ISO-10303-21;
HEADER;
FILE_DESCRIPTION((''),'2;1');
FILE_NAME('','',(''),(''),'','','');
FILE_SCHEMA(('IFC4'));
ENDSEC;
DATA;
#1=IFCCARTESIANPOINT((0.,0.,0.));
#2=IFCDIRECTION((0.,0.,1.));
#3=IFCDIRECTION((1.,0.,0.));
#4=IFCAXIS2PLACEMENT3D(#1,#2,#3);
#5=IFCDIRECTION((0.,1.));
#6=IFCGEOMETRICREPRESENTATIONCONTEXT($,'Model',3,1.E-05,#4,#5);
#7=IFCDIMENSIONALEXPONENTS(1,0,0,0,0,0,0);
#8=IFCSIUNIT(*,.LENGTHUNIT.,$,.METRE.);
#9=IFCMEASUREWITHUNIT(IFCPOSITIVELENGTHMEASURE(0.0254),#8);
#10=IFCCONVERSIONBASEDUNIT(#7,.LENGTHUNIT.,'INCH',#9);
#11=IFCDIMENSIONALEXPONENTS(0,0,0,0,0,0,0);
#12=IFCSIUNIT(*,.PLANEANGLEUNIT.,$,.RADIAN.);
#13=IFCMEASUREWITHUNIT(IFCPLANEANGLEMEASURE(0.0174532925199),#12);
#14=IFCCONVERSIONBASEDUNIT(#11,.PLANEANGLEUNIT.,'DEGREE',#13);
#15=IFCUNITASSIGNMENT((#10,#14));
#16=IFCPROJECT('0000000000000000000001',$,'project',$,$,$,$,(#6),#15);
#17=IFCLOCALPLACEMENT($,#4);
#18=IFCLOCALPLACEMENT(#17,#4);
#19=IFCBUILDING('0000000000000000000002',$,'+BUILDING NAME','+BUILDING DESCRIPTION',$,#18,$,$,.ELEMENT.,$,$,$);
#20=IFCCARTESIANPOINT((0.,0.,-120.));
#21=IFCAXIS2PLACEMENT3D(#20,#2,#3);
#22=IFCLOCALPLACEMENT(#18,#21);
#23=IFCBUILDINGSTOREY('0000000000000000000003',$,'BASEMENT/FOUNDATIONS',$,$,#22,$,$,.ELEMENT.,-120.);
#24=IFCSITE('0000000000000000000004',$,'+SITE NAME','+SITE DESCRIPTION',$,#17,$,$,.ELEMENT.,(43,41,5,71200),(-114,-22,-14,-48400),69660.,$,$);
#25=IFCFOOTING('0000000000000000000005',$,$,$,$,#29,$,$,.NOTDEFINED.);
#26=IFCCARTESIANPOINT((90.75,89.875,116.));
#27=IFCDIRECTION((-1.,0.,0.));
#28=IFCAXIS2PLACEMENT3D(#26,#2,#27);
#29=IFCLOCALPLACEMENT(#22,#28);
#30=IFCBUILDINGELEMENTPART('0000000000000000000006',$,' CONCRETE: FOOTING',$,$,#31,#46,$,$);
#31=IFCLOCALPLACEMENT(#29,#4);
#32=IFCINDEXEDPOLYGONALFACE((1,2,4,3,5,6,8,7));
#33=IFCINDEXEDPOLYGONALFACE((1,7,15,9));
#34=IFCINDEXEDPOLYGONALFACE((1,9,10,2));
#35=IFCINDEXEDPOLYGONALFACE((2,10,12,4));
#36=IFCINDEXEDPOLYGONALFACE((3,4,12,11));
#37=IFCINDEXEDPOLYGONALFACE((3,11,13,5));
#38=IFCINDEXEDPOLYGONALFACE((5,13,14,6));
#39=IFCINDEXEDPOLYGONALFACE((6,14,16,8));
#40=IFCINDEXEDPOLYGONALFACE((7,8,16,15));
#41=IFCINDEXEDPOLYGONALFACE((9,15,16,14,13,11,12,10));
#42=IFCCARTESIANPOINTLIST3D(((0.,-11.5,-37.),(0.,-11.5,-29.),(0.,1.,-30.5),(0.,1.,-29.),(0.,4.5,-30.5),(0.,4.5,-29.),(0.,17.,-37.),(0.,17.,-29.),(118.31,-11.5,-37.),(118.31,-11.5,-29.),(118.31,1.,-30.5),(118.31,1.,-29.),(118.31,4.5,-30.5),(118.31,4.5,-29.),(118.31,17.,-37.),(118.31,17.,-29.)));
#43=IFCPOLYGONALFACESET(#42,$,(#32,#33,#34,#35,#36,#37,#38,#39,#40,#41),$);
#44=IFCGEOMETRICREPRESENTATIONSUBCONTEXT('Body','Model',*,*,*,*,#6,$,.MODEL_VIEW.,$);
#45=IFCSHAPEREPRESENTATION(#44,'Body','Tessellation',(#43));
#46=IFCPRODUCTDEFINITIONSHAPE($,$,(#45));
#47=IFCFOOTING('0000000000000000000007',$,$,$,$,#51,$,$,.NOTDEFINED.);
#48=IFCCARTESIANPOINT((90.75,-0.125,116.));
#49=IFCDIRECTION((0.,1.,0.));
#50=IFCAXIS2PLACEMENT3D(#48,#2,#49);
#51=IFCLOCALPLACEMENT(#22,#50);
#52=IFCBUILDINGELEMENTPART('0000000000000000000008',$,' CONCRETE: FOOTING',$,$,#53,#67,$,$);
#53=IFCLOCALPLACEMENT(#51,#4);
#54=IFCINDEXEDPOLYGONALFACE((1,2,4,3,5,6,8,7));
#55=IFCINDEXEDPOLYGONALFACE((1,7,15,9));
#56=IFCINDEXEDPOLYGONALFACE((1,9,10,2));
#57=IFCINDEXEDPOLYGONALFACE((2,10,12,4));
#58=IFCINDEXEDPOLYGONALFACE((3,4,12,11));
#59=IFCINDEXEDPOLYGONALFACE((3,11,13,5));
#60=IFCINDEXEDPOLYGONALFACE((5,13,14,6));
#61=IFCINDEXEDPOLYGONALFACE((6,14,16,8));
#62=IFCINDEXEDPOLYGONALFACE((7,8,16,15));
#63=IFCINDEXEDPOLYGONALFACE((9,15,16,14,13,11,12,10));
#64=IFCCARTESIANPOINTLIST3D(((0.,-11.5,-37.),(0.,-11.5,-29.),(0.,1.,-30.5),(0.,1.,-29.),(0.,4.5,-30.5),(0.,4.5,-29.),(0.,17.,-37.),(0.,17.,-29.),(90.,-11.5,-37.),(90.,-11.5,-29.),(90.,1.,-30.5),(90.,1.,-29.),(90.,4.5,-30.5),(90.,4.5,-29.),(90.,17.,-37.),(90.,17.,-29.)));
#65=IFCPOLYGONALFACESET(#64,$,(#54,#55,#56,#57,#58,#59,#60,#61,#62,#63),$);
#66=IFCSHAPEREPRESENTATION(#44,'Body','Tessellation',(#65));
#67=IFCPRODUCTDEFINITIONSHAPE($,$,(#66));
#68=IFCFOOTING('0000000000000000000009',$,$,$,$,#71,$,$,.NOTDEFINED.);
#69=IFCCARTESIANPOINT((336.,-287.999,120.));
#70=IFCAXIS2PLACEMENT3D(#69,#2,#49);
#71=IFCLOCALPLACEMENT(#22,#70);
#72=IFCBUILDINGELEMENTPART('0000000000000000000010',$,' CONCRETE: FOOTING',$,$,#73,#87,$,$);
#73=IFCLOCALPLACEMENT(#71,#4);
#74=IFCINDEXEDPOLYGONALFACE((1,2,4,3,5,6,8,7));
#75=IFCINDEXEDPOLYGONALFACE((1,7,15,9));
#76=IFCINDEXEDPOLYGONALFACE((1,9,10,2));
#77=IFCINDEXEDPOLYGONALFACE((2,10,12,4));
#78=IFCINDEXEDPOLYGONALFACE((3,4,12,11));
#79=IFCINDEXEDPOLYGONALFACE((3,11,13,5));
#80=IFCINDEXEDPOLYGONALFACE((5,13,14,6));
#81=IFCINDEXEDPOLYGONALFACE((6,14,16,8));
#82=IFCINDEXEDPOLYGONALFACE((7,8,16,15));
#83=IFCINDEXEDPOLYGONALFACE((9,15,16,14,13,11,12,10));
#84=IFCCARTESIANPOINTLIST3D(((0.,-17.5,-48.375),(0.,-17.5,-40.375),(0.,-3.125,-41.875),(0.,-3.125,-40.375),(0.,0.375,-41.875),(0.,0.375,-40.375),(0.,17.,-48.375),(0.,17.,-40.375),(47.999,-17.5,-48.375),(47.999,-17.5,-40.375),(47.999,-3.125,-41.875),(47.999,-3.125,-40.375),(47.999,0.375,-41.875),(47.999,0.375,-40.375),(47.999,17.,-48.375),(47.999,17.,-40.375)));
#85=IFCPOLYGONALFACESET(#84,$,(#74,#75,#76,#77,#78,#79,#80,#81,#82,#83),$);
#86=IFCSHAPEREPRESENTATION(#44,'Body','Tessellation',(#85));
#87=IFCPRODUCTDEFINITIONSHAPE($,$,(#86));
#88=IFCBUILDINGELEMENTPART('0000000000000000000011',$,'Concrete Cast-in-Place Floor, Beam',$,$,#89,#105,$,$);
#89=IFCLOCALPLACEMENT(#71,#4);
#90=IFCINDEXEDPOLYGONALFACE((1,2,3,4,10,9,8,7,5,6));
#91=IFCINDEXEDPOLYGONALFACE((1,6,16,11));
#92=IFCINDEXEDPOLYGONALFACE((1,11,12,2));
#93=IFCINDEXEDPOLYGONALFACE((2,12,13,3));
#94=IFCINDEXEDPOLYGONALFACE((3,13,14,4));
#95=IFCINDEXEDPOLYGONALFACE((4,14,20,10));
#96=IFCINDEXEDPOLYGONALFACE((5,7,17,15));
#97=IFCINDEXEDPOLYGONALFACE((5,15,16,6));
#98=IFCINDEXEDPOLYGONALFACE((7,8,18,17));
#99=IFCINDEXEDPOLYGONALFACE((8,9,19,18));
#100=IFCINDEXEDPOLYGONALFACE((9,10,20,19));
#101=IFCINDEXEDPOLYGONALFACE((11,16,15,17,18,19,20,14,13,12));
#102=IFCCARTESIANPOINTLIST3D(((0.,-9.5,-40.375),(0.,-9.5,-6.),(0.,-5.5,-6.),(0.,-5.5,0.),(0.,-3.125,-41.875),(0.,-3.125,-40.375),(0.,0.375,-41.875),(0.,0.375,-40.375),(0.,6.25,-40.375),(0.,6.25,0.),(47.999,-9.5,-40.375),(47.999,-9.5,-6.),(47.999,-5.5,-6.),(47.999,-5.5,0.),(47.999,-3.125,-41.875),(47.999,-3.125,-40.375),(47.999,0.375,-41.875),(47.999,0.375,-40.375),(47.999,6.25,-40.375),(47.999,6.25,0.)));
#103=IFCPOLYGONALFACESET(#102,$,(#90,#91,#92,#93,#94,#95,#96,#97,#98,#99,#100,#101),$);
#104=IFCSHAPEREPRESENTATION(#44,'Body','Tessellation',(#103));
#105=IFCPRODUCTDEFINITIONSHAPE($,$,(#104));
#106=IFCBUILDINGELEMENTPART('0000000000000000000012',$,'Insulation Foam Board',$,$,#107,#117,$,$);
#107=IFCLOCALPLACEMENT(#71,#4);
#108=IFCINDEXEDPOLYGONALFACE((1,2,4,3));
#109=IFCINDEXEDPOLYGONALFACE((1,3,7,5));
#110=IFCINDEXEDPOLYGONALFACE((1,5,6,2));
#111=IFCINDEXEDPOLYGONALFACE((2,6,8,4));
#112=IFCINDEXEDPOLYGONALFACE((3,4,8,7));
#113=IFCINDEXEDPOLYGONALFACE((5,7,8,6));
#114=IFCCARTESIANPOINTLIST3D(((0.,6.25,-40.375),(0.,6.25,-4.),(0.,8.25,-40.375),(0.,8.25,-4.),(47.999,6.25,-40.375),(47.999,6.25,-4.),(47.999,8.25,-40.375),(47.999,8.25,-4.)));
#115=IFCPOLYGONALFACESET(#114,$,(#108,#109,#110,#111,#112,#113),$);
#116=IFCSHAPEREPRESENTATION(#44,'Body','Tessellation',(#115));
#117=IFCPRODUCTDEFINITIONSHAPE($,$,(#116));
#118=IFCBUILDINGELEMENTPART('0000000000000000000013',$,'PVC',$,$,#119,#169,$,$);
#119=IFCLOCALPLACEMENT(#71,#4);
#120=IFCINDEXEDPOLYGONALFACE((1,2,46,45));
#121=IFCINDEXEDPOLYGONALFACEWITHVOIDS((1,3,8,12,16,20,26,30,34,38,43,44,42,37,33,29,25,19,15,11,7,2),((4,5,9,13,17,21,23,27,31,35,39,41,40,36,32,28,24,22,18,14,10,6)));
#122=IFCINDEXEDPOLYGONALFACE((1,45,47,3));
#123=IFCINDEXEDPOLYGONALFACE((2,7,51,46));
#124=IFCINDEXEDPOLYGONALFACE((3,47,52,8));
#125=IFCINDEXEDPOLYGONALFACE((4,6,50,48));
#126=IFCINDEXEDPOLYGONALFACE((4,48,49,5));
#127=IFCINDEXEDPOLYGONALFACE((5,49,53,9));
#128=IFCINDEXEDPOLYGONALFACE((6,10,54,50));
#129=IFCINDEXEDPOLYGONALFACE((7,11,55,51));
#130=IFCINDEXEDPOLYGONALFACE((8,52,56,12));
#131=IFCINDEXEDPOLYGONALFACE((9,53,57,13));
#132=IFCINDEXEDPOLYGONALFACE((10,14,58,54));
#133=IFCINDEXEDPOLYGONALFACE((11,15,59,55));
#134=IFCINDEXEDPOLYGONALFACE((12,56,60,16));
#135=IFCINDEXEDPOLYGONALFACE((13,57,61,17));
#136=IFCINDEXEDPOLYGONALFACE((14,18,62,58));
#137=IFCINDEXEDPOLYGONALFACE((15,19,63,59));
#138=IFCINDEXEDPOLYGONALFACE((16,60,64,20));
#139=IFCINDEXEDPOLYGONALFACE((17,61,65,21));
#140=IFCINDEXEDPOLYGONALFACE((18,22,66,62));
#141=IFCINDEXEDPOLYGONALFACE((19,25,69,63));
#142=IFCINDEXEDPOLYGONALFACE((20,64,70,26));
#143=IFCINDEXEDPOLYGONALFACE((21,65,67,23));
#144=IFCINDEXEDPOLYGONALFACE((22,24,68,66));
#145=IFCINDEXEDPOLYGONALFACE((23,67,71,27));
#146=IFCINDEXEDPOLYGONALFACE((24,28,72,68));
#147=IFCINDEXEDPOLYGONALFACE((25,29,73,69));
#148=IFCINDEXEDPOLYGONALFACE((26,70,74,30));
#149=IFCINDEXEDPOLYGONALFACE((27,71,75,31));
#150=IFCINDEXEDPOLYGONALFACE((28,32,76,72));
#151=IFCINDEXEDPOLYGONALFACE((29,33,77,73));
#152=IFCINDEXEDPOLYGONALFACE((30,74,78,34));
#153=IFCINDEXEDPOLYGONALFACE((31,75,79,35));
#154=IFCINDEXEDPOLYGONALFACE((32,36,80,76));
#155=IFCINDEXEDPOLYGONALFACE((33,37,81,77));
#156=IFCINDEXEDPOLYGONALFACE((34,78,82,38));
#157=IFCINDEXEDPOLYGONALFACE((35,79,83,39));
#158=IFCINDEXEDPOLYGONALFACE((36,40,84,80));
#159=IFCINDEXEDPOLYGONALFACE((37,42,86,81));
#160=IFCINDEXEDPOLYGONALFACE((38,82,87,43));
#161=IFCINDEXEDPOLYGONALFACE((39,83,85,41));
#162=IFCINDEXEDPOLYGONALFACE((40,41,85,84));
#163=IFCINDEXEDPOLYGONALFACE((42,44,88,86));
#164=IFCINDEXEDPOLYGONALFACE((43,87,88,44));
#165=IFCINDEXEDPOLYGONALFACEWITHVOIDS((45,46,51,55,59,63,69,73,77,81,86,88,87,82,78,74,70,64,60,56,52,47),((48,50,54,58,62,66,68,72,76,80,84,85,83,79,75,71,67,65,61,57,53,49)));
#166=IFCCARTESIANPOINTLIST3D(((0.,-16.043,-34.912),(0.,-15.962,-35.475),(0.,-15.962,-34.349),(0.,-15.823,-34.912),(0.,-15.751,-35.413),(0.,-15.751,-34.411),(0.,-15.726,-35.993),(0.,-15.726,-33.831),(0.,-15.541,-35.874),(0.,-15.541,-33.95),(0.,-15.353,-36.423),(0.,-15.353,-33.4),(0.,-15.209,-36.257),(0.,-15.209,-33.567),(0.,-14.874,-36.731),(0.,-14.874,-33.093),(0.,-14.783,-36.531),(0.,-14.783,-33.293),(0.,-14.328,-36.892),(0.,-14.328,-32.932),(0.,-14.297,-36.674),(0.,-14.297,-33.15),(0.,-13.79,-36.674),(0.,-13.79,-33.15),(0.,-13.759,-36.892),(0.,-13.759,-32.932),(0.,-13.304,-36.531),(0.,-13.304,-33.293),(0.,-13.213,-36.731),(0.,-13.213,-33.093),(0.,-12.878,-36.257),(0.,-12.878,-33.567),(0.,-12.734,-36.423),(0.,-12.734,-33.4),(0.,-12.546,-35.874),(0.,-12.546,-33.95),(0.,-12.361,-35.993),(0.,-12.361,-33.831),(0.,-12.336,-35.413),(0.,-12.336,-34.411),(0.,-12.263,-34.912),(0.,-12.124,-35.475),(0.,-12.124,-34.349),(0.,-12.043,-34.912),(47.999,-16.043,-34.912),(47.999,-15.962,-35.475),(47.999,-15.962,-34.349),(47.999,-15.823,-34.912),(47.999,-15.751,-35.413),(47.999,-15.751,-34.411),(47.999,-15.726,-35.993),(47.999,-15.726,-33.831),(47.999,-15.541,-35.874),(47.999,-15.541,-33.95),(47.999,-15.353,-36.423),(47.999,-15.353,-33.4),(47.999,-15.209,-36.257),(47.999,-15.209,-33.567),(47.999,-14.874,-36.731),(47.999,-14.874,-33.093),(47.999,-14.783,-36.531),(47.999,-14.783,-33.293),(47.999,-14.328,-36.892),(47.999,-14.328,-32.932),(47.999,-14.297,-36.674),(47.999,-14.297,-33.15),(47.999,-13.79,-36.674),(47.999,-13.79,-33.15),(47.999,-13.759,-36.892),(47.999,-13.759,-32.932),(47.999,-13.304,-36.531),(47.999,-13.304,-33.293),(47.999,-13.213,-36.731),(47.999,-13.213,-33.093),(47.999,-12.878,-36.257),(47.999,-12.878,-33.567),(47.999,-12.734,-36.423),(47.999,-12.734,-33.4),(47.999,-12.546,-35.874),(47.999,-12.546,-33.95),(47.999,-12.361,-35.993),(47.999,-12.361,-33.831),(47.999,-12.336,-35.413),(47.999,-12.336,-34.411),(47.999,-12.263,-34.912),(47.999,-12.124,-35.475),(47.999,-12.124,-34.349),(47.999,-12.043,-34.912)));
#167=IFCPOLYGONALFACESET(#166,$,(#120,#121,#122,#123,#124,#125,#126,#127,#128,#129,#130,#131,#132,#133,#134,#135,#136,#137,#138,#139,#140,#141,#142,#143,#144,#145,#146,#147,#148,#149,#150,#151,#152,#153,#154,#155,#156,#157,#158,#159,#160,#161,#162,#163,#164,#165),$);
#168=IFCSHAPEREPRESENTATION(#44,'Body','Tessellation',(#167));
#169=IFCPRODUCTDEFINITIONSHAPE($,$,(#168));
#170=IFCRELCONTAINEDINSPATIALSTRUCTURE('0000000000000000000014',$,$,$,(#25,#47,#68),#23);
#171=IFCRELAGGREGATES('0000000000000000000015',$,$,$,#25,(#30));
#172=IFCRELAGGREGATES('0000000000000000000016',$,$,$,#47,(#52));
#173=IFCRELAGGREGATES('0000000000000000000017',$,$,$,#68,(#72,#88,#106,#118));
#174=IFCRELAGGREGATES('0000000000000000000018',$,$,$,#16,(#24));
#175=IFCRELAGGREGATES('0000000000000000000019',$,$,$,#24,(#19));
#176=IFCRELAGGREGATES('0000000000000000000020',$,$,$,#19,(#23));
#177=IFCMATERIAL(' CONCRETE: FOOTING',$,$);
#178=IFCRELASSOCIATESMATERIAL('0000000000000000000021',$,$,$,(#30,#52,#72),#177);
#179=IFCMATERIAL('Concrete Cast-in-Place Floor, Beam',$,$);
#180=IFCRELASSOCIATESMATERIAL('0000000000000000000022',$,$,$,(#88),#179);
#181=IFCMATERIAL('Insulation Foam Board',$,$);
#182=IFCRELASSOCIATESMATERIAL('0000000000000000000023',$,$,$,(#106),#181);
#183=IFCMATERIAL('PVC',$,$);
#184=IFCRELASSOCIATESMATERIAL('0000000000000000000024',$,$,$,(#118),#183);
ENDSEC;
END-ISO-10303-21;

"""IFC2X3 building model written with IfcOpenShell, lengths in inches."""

from ifc_helpers import new_model, entity, si_unit, converted_unit, point, direction, frame, frame_2d, origin_with_axes, place, context, subcontext, project, spatial, polyline, circle_curve, parameter, trimmed, segment, composite_curve, outline, extrude, material, element, aggregate, save


model = new_model("IFC2X3")

# Units and contexts
model_context = context("Model", 3, precision=1e-05, world=origin_with_axes(), true_north=direction((0.0, 1.0)))
body_context = subcontext(model_context, "Body", "Model", "MODEL_VIEW")
ifc_project = project(units=[converted_unit("LENGTHUNIT", "INCH", entity("IfcPositiveLengthMeasure", 0.0254), si_unit("LENGTHUNIT", "METRE"), dimensions=[1, 0, 0, 0, 0, 0, 0]), converted_unit("PLANEANGLEUNIT", "DEGREE", entity("IfcPlaneAngleMeasure", 0.0174532925199), si_unit("PLANEANGLEUNIT", "RADIAN"), dimensions=[0, 0, 0, 0, 0, 0, 0])], contexts=[model_context])

# Site, building, storey
site_placement = place(None, origin_with_axes())
site = spatial("IfcSite", under=ifc_project, at=site_placement, Name="+SITE NAME", Description="+SITE DESCRIPTION", CompositionType="ELEMENT", RefLatitude=(43, 41, 5, 71200), RefLongitude=(-114, -22, -14, -48400), RefElevation=69660.0)
building_placement = place(site_placement, origin_with_axes())
building = spatial("IfcBuilding", under=site, at=building_placement, Name="+BUILDING NAME", Description="+BUILDING DESCRIPTION", CompositionType="ELEMENT")
storey_placement = place(building_placement, frame((0.0, 0.0, -120.0), z_axis=(0.0, 0.0, 1.0), x_axis=(1.0, 0.0, 0.0)))
storey = spatial("IfcBuildingStorey", under=building, at=storey_placement, Name="BASEMENT/FOUNDATIONS", CompositionType="ELEMENT", Elevation=-120.0)

# Footings, building element parts
footing_1_placement = place(storey_placement, frame((90.75, 89.875, 116.0), z_axis=(0.0, 0.0, 1.0), x_axis=(-1.0, 0.0, 0.0)))
footing_1 = element("IfcFooting", 1, at=footing_1_placement, inside=storey, PredefinedType="NOTDEFINED")
ifc_material_1 = material(Name=" CONCRETE: FOOTING")
building_element_part_1_placement = place(footing_1_placement, origin_with_axes())
building_element_part_1 = element("IfcBuildingElementPart", 2, at=building_element_part_1_placement, material=ifc_material_1, Name=" CONCRETE: FOOTING", context=body_context, shape_type="SweptSolid", body=[
    extrude(outline(polyline([(-14.25, -37.0), (14.25, -37.0), (14.25, -29.0), (1.75, -29.0), (1.75, -30.5), (-1.75, -30.5), (-1.75, -29.0), (-14.25, -29.0), (-14.25, -37.0)])), frame((0.0, 2.75, 0.0), z_axis=(1.0, 0.0, 0.0), x_axis=(0.0, 1.0, 0.0)), (0.0, 0.0, 1.0), 118.31),
])
ifc_material_2 = material(Name="Concrete Cast-in-Place Floor, Beam")
aggregate(footing_1, [building_element_part_1])
footing_2_placement = place(storey_placement, frame((90.75, -0.125, 116.0), z_axis=(0.0, 0.0, 1.0), x_axis=(0.0, 1.0, 0.0)))
footing_2 = element("IfcFooting", 3, at=footing_2_placement, inside=storey, PredefinedType="NOTDEFINED")
building_element_part_2_placement = place(footing_2_placement, origin_with_axes())
building_element_part_2 = element("IfcBuildingElementPart", 4, at=building_element_part_2_placement, material=ifc_material_1, Name=" CONCRETE: FOOTING", context=body_context, shape_type="SweptSolid", body=[
    extrude(outline(polyline([(-14.25, -37.0), (14.25, -37.0), (14.25, -29.0), (1.75, -29.0), (1.75, -30.5), (-1.75, -30.5), (-1.75, -29.0), (-14.25, -29.0), (-14.25, -37.0)])), frame((0.0, 2.75, 0.0), z_axis=(1.0, 0.0, 0.0), x_axis=(0.0, 1.0, 0.0)), (0.0, 0.0, 1.0), 90.0),
])
aggregate(footing_2, [building_element_part_2])
footing_3_placement = place(storey_placement, frame((336.0, -287.999, 120.0), z_axis=(0.0, 0.0, 1.0), x_axis=(0.0, 1.0, 0.0)))
footing_3 = element("IfcFooting", 5, at=footing_3_placement, inside=storey, PredefinedType="NOTDEFINED")
building_element_part_3_placement = place(footing_3_placement, origin_with_axes())
building_element_part_3 = element("IfcBuildingElementPart", 6, at=building_element_part_3_placement, material=ifc_material_1, Name=" CONCRETE: FOOTING", context=body_context, shape_type="SweptSolid", body=[
    extrude(outline(polyline([(-17.0, -48.375), (17.5, -48.375), (17.5, -40.375), (3.125, -40.375), (3.125, -41.875), (-0.375, -41.875), (-0.375, -40.375), (-17.0, -40.375), (-17.0, -48.375)])), frame((0.0, 0.0, 0.0), z_axis=(-1.0, 0.0, 0.0), x_axis=(0.0, -1.0, 0.0)), (0.0, 0.0, -1.0), 47.999),
])
building_element_part_4_placement = place(footing_3_placement, origin_with_axes())
building_element_part_4 = element("IfcBuildingElementPart", 7, at=building_element_part_4_placement, material=ifc_material_2, Name="Concrete Cast-in-Place Floor, Beam", context=body_context, shape_type="SweptSolid", body=[
    extrude(outline(polyline([(-6.25, 0.0), (-6.25, -40.375), (-0.375, -40.375), (-0.375, -41.875), (3.125, -41.875), (3.125, -40.375), (9.5, -40.375), (9.5, -6.0), (5.5, -6.0), (5.5, 0.0), (-6.25, 0.0)])), frame((0.0, 0.0, 0.0), z_axis=(-1.0, 0.0, 0.0), x_axis=(0.0, -1.0, 0.0)), (0.0, 0.0, -1.0), 47.999),
])
ifc_material_3 = material(Name="Insulation Foam Board")
building_element_part_5_placement = place(footing_3_placement, origin_with_axes())
building_element_part_5 = element("IfcBuildingElementPart", 8, at=building_element_part_5_placement, material=ifc_material_3, Name="Insulation Foam Board", context=body_context, shape_type="SweptSolid", body=[
    extrude(outline(polyline([(-6.25, -4.0), (-8.25, -4.0), (-8.25, -40.375), (-6.25, -40.375), (-6.25, -4.0)])), frame((0.0, 0.0, 0.0), z_axis=(-1.0, 0.0, 0.0), x_axis=(0.0, -1.0, 0.0)), (0.0, 0.0, -1.0), 47.999),
])
ifc_material_4 = material(Name="PVC")
building_element_part_6_placement = place(footing_3_placement, origin_with_axes())
building_element_part_6 = element("IfcBuildingElementPart", 9, at=building_element_part_6_placement, material=ifc_material_4, Name="PVC", context=body_context, shape_type="SweptSolid", body=[
    extrude(outline(composite_curve([segment(trimmed(circle_curve(frame_2d((14.043, -34.912), x_axis=(1.0, 0.0)), 2.0), [point((16.043, -34.912)), parameter(0.0)], [point((12.043, -34.912)), parameter(180.0)], True, "CARTESIAN"), True, "CONTINUOUS"), segment(trimmed(circle_curve(frame_2d((14.043, -34.912), x_axis=(-1.0, 0.0)), 2.0), [point((12.043, -34.912)), parameter(0.0)], [point((16.043, -34.912)), parameter(180.0)], True, "CARTESIAN"), True, "CONTINUOUS")], self_intersect=False), holes=[composite_curve([segment(trimmed(circle_curve(frame_2d((14.043, -34.912), x_axis=(-1.0, 0.0)), 1.78), [point((15.823, -34.912)), parameter(180.0)], [point((12.263, -34.912)), parameter(0.0)], False, "CARTESIAN"), True, "CONTINUOUS"), segment(trimmed(circle_curve(frame_2d((14.043, -34.912), x_axis=(1.0, 0.0)), 1.78), [point((12.263, -34.912)), parameter(180.0)], [point((15.823, -34.912)), parameter(0.0)], False, "CARTESIAN"), True, "CONTINUOUS")], self_intersect=False)]), frame((0.0, 0.0, 0.0), z_axis=(-1.0, 0.0, 0.0), x_axis=(0.0, -1.0, 0.0)), (0.0, 0.0, -1.0), 47.999),
])
aggregate(footing_3, [building_element_part_3, building_element_part_4, building_element_part_5, building_element_part_6])

save(model, "model.ifc")
